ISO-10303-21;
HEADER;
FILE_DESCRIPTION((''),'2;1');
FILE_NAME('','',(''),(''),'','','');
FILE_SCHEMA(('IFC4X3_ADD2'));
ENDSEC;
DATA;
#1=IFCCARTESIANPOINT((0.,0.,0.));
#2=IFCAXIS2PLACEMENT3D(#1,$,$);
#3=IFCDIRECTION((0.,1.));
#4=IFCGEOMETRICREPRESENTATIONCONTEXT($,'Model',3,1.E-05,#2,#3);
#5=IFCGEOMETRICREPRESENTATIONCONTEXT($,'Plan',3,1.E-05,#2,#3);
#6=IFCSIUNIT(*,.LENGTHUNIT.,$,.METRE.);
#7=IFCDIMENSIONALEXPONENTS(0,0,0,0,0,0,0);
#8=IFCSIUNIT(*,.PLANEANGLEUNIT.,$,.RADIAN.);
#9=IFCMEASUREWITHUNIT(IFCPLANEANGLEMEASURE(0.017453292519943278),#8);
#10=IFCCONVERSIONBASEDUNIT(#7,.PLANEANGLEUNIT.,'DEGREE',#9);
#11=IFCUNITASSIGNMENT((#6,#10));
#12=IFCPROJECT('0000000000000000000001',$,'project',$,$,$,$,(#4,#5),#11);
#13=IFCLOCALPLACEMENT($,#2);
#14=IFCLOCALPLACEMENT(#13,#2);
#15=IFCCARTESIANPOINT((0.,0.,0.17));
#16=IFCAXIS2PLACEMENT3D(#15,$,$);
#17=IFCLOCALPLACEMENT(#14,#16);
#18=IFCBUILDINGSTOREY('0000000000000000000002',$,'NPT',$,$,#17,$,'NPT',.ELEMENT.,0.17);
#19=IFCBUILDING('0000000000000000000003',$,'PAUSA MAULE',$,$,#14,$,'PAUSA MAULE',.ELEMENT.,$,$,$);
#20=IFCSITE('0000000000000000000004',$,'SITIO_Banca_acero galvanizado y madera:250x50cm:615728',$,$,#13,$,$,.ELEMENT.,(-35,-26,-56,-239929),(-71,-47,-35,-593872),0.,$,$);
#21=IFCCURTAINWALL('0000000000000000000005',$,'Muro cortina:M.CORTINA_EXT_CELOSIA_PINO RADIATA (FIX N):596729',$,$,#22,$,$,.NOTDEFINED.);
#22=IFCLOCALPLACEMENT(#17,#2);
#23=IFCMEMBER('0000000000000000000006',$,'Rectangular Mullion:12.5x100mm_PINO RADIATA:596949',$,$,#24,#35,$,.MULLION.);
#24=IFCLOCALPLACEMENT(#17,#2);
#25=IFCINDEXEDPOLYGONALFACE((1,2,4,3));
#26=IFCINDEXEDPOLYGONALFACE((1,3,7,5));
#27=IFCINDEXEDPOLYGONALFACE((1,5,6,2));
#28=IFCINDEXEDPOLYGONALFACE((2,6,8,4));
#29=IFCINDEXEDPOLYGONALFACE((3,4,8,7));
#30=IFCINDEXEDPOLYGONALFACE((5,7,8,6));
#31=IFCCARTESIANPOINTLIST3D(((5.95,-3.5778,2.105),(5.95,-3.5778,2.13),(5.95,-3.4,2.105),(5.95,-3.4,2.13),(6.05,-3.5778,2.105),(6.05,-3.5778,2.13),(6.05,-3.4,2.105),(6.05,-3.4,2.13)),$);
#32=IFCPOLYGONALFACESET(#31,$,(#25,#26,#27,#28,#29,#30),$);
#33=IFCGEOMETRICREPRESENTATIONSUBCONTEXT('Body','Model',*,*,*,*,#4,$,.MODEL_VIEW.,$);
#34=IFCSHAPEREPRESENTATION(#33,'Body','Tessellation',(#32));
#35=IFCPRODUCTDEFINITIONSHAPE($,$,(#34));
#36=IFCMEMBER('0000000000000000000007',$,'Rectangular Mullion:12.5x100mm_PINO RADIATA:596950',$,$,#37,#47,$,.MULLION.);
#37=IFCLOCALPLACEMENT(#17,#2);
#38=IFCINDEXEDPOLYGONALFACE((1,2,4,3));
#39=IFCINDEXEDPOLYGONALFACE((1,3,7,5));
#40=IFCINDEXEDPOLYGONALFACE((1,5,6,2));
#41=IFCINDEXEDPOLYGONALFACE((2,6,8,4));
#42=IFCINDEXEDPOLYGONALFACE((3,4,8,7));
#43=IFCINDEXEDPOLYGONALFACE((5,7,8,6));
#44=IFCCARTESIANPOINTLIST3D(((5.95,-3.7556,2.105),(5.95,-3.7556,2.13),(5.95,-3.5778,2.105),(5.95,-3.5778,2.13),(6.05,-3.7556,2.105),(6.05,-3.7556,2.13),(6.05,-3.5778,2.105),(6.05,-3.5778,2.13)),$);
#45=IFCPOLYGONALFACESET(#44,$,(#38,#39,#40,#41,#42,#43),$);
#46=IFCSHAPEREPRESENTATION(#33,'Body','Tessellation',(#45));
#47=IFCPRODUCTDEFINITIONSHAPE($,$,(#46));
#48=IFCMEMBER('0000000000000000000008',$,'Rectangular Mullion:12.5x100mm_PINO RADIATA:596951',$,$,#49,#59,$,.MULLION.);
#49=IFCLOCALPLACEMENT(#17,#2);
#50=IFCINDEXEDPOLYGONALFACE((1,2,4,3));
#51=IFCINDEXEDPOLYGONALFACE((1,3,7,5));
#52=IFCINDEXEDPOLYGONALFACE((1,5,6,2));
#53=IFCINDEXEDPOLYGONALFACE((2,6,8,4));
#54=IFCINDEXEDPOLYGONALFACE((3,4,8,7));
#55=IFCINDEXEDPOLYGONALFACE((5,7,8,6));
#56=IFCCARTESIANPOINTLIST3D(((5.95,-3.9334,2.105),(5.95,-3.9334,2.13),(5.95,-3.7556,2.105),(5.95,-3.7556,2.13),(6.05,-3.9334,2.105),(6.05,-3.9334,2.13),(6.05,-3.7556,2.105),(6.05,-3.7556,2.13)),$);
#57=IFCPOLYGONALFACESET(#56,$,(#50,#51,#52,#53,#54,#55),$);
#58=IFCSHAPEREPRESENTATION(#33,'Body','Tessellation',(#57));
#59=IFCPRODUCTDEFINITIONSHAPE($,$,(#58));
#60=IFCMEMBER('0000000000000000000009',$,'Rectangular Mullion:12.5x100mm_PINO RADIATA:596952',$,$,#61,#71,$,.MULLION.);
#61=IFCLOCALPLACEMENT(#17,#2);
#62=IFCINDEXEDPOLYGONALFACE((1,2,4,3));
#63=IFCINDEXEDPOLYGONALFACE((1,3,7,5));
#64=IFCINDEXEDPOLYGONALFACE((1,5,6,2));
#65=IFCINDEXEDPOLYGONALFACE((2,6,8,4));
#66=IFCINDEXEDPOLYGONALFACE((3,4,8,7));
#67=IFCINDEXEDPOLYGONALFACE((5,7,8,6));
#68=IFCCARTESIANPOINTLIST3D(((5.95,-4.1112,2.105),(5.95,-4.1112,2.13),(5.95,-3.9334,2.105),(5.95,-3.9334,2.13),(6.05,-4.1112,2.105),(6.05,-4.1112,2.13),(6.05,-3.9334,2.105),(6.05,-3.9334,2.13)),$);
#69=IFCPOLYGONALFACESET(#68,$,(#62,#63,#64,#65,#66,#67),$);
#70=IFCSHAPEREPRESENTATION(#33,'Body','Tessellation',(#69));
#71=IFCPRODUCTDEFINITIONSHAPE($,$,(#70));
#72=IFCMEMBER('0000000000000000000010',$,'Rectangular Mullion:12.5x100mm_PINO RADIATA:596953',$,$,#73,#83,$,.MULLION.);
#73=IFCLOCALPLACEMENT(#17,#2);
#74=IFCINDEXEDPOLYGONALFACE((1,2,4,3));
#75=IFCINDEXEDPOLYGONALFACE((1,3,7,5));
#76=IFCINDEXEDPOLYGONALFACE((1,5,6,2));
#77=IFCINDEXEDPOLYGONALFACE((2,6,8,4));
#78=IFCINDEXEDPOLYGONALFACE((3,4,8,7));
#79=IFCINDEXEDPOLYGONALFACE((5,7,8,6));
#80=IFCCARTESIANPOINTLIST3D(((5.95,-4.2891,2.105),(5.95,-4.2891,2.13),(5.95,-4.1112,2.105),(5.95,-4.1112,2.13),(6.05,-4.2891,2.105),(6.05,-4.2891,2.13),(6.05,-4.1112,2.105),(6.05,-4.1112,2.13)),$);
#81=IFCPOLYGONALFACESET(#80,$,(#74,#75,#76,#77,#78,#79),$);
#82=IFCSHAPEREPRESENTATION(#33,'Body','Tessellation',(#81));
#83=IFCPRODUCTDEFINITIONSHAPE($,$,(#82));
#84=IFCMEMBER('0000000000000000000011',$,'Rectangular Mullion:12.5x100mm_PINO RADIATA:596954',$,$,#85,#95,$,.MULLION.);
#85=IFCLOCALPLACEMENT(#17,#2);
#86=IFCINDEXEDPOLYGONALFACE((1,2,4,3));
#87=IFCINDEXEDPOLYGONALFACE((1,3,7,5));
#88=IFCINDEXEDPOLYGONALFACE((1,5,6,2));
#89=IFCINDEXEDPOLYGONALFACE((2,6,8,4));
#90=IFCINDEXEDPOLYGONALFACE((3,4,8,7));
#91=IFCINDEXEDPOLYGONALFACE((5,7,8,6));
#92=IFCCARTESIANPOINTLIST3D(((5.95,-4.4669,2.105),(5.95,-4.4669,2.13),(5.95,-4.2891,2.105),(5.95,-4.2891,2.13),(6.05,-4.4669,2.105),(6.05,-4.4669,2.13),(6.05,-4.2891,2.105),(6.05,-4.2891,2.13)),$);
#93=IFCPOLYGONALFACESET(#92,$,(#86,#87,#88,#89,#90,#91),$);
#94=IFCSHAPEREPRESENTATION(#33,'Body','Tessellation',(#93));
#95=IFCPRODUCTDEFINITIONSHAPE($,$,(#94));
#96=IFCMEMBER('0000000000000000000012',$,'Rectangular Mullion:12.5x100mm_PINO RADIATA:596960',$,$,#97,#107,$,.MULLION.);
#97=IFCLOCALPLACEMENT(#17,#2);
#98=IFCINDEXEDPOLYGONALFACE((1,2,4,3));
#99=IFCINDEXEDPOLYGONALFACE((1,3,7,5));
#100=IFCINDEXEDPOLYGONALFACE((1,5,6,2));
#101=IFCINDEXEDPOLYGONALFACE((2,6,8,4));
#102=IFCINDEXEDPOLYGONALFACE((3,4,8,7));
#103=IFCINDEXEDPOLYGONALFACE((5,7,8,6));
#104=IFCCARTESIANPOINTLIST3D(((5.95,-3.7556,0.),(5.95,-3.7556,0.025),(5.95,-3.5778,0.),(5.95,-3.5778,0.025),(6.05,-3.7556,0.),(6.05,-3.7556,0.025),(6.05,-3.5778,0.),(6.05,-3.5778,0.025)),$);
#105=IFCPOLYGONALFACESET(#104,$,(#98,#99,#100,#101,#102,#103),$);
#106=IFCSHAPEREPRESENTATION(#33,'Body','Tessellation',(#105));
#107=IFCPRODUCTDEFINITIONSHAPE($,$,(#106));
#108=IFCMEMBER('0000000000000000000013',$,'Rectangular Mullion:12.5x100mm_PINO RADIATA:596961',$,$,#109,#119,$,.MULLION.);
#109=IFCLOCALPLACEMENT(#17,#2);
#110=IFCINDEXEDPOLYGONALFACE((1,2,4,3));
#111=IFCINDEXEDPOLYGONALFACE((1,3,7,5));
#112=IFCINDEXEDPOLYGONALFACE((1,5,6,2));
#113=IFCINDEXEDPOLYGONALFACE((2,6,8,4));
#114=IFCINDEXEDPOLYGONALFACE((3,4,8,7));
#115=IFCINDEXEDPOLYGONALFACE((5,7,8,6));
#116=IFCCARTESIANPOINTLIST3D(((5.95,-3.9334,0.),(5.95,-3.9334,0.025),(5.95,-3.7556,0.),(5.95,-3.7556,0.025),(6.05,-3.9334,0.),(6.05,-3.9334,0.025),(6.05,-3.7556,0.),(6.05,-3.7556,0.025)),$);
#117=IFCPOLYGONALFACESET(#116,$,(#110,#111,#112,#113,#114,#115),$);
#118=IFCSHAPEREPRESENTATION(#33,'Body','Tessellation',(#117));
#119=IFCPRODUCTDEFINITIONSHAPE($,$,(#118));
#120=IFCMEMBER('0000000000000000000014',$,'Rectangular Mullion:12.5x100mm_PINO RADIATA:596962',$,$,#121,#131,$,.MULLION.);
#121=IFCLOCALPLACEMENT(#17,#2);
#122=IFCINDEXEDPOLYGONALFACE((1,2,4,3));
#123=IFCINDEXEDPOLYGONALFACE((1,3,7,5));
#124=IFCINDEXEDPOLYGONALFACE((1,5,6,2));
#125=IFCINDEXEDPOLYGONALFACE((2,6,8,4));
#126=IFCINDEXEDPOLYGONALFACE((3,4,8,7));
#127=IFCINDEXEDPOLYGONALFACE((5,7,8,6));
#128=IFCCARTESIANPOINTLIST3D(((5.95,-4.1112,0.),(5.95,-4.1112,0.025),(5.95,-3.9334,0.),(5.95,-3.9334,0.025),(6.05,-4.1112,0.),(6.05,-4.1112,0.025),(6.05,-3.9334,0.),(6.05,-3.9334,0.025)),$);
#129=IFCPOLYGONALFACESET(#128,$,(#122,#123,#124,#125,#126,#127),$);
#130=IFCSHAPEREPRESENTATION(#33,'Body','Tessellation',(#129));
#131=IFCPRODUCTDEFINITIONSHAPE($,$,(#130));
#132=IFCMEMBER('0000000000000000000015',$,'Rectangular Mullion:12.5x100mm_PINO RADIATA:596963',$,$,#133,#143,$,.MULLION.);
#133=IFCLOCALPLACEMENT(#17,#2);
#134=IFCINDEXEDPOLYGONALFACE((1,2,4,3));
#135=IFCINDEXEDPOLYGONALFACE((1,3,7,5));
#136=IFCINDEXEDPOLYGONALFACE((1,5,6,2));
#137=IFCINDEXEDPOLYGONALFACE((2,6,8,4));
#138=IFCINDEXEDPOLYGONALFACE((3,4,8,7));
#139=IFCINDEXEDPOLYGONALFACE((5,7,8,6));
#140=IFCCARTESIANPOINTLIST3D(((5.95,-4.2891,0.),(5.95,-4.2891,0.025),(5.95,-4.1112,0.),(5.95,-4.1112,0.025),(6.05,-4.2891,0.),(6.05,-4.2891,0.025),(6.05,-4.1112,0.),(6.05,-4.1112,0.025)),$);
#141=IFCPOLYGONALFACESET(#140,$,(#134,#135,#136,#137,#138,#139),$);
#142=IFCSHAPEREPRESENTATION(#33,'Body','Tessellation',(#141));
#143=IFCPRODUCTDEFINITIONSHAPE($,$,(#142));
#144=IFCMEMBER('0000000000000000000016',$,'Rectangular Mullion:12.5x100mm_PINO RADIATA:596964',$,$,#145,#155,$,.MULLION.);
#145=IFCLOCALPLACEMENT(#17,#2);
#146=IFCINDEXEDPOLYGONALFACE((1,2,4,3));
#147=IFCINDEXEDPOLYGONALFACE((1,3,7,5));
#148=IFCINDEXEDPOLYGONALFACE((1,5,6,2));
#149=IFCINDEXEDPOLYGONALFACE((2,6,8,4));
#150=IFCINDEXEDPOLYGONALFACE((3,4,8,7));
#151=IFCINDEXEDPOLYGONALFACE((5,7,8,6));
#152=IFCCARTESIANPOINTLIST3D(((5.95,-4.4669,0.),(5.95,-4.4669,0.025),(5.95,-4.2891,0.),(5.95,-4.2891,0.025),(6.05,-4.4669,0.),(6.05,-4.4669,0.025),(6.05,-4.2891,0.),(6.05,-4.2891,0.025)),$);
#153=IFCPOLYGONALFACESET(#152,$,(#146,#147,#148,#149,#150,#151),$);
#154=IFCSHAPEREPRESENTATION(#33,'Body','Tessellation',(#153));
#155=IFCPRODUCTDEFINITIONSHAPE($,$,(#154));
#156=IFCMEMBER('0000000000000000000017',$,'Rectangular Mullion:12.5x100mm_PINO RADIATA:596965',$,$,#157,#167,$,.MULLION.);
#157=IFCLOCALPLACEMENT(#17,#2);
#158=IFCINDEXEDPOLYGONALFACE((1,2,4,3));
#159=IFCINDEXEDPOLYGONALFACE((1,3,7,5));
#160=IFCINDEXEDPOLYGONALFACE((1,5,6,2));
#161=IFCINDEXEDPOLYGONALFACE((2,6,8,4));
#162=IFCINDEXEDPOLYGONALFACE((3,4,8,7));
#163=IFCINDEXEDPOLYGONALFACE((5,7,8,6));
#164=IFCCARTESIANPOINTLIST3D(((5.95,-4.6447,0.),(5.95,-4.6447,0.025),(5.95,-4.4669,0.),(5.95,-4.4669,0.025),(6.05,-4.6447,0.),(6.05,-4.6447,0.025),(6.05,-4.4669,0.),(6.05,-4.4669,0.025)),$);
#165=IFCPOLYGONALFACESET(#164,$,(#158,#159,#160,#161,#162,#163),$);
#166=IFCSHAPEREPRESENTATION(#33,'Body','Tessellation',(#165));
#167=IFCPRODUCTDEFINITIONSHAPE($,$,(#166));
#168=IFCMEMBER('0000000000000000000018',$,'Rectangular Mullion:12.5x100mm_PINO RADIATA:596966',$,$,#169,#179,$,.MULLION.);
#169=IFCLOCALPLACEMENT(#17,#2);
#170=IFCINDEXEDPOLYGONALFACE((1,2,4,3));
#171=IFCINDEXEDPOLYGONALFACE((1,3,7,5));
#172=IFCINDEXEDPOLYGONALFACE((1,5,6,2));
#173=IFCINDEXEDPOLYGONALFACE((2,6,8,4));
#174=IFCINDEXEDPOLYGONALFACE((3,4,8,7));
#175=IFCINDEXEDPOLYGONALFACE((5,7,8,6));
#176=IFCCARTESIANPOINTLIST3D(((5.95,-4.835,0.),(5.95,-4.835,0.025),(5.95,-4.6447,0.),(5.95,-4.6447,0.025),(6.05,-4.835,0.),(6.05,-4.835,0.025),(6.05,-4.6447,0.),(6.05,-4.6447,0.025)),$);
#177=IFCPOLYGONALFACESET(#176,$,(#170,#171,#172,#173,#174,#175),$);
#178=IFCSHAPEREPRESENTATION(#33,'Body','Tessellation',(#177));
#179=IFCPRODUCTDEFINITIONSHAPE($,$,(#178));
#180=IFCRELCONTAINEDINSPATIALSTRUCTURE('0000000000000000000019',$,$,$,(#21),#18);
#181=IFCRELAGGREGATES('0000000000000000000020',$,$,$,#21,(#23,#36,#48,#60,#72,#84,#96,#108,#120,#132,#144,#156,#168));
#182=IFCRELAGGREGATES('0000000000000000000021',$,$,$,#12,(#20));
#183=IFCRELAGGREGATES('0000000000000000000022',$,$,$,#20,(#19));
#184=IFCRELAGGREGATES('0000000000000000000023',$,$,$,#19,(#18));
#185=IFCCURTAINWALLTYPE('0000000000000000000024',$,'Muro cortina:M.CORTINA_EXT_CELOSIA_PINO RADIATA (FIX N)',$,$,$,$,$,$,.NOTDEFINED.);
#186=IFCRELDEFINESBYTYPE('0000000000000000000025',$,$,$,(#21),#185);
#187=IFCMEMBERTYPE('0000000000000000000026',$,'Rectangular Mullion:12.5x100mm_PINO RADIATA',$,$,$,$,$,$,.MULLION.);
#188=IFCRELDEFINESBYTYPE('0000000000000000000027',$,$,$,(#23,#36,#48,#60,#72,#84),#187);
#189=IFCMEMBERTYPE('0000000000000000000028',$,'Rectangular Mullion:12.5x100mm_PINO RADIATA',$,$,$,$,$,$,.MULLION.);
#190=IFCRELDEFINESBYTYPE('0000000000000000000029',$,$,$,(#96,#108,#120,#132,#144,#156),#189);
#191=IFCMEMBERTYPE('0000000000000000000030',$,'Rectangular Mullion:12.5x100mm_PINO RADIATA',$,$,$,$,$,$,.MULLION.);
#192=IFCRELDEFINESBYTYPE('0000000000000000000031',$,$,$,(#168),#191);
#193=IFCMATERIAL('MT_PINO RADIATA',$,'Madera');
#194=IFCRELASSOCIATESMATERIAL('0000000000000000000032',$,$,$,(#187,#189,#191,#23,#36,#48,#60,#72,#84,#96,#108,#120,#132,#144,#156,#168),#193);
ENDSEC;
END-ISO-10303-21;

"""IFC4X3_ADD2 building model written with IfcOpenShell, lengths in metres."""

from ifc_helpers import new_model, entity, si_unit, converted_unit, direction, frame, frame_2d, origin, place, context, subcontext, project, spatial, rectangle, extrude, source, transform, mapped, material, material_profile, profile_set, profile_usage, type_object, type_shapes, element, aggregate, save


model = new_model("IFC4X3_ADD2")

# Units and contexts
model_context = context("Model", 3, precision=1e-05, world=origin(), true_north=direction((0.0, 1.0)))
plan_context = context("Plan", 3, precision=1e-05, world=origin(), true_north=direction((0.0, 1.0)))
body_context = subcontext(model_context, "Body", "Model", "MODEL_VIEW")
ifc_project = project(units=[si_unit("LENGTHUNIT", "METRE"), converted_unit("PLANEANGLEUNIT", "DEGREE", entity("IfcPlaneAngleMeasure", 0.017453292519943278), si_unit("PLANEANGLEUNIT", "RADIAN"), dimensions=[0, 0, 0, 0, 0, 0, 0])], contexts=[model_context, plan_context])

# Site, building, storey
site_placement = place(None, origin())
site = spatial("IfcSite", under=ifc_project, at=site_placement, Name="SITIO_Banca_acero galvanizado y madera:250x50cm:615728", CompositionType="ELEMENT", RefLatitude=(-35, -26, -56, -239929), RefLongitude=(-71, -47, -35, -593872), RefElevation=0.0)
building_placement = place(site_placement, origin())
building = spatial("IfcBuilding", under=site, at=building_placement, Name="PAUSA MAULE", LongName="PAUSA MAULE", CompositionType="ELEMENT")
storey_placement = place(building_placement, frame((0.0, 0.0, 0.17)))
storey = spatial("IfcBuildingStorey", under=building, at=storey_placement, Name="NPT", LongName="NPT", CompositionType="ELEMENT", Elevation=0.17)

# Curtain wall, members
curtain_wall_type = type_object("IfcCurtainWallType", Name="Muro cortina:M.CORTINA_EXT_CELOSIA_PINO RADIATA (FIX N)", PredefinedType="NOTDEFINED")
curtain_wall_placement = place(storey_placement, frame((0.0, 0.0, -0.17)))
curtain_wall = element("IfcCurtainWall", 1, at=curtain_wall_placement, inside=storey, type_object=curtain_wall_type, Name="Muro cortina:M.CORTINA_EXT_CELOSIA_PINO RADIATA (FIX N):596729", PredefinedType="NOTDEFINED")
ifc_material = material(Name="MT_PINO RADIATA", Category="Madera")
ifc_material_profile = material_profile(ifc_material, rectangle(XDim=0.025, YDim=0.1, at=frame_2d((0.0, 0.0), x_axis=(1.0, 0.0))), Name="12.5x100mm_PINO RADIATA")
ifc_profile_set = profile_set([ifc_material_profile], Name="12.5x100mm_PINO RADIATA")
ifc_profile_usage = profile_usage(ifc_profile_set)
member_type_1 = type_object("IfcMemberType", Name="Rectangular Mullion:12.5x100mm_PINO RADIATA", PredefinedType="MULLION", material=ifc_profile_set)
shared_shape_1 = source(origin(), body_context, "Body", "SweptSolid", [
    extrude(rectangle(XDim=0.025, YDim=0.1, at=frame_2d((0.0, 0.0), x_axis=(1.0, 0.0))), frame((-0.0125, 0.0, -0.1778), z_axis=(0.0, 0.0, 1.0), x_axis=(-1.0, 0.0, 0.0)), (0.0, 0.0, 1.0), 0.1778),
])
type_shapes(member_type_1, [shared_shape_1])
member_1_placement = place(curtain_wall_placement, frame((6.0, -3.5778, 2.3), z_axis=(0.0, -1.0, 0.0), x_axis=(0.0, 0.0, 1.0)))
member_1 = element("IfcMember", 2, at=member_1_placement, type_object=member_type_1, material=ifc_profile_usage, Name="Rectangular Mullion:12.5x100mm_PINO RADIATA:596949", PredefinedType="MULLION", context=body_context, shape_type="MappedRepresentation", body=[
    mapped(shared_shape_1, transform((0.0, 0.0, 0.0), scale=1.0)),
])
member_2_placement = place(curtain_wall_placement, frame((6.0, -3.7556, 2.3), z_axis=(0.0, -1.0, 0.0), x_axis=(0.0, 0.0, 1.0)))
member_2 = element("IfcMember", 3, at=member_2_placement, type_object=member_type_1, material=ifc_profile_usage, Name="Rectangular Mullion:12.5x100mm_PINO RADIATA:596950", PredefinedType="MULLION", context=body_context, shape_type="MappedRepresentation", body=[
    mapped(shared_shape_1, transform((0.0, 0.0, 0.0), scale=1.0)),
])
member_3_placement = place(curtain_wall_placement, frame((6.0, -3.9334, 2.3), z_axis=(0.0, -1.0, 0.0), x_axis=(0.0, 0.0, 1.0)))
member_3 = element("IfcMember", 4, at=member_3_placement, type_object=member_type_1, material=ifc_profile_usage, Name="Rectangular Mullion:12.5x100mm_PINO RADIATA:596951", PredefinedType="MULLION", context=body_context, shape_type="MappedRepresentation", body=[
    mapped(shared_shape_1, transform((0.0, 0.0, 0.0), scale=1.0)),
])
member_4_placement = place(curtain_wall_placement, frame((6.0, -4.1112, 2.3), z_axis=(0.0, -1.0, 0.0), x_axis=(0.0, 0.0, 1.0)))
member_4 = element("IfcMember", 5, at=member_4_placement, type_object=member_type_1, material=ifc_profile_usage, Name="Rectangular Mullion:12.5x100mm_PINO RADIATA:596952", PredefinedType="MULLION", context=body_context, shape_type="MappedRepresentation", body=[
    mapped(shared_shape_1, transform((0.0, 0.0, 0.0), scale=1.0)),
])
member_5_placement = place(curtain_wall_placement, frame((6.0, -4.2891, 2.3), z_axis=(0.0, -1.0, 0.0), x_axis=(0.0, 0.0, 1.0)))
member_5 = element("IfcMember", 6, at=member_5_placement, type_object=member_type_1, material=ifc_profile_usage, Name="Rectangular Mullion:12.5x100mm_PINO RADIATA:596953", PredefinedType="MULLION", context=body_context, shape_type="MappedRepresentation", body=[
    mapped(shared_shape_1, transform((0.0, 0.0, 0.0), scale=1.0)),
])
member_6_placement = place(curtain_wall_placement, frame((6.0, -4.4669, 2.3), z_axis=(0.0, -1.0, 0.0), x_axis=(0.0, 0.0, 1.0)))
member_6 = element("IfcMember", 7, at=member_6_placement, type_object=member_type_1, material=ifc_profile_usage, Name="Rectangular Mullion:12.5x100mm_PINO RADIATA:596954", PredefinedType="MULLION", context=body_context, shape_type="MappedRepresentation", body=[
    mapped(shared_shape_1, transform((0.0, 0.0, 0.0), scale=1.0)),
])
member_type_2 = type_object("IfcMemberType", Name="Rectangular Mullion:12.5x100mm_PINO RADIATA", PredefinedType="MULLION", material=ifc_profile_set)
shared_shape_2 = source(origin(), body_context, "Body", "SweptSolid", [
    extrude(rectangle(XDim=0.025, YDim=0.1, at=frame_2d((0.0, 0.0), x_axis=(1.0, 0.0))), frame((-0.0125, 0.0, -0.1778), z_axis=(0.0, 0.0, 1.0), x_axis=(-1.0, 0.0, 0.0)), (0.0, 0.0, 1.0), 0.1778),
])
type_shapes(member_type_2, [shared_shape_2])
member_7_placement = place(curtain_wall_placement, frame((6.0, -3.5778, 0.17), z_axis=(0.0, 1.0, 0.0), x_axis=(0.0, 0.0, -1.0)))
member_7 = element("IfcMember", 8, at=member_7_placement, type_object=member_type_2, material=ifc_profile_usage, Name="Rectangular Mullion:12.5x100mm_PINO RADIATA:596960", PredefinedType="MULLION", context=body_context, shape_type="MappedRepresentation", body=[
    mapped(shared_shape_2, transform((0.0, 0.0, 0.0), scale=1.0)),
])
member_8_placement = place(curtain_wall_placement, frame((6.0, -3.7556, 0.17), z_axis=(0.0, 1.0, 0.0), x_axis=(0.0, 0.0, -1.0)))
member_8 = element("IfcMember", 9, at=member_8_placement, type_object=member_type_2, material=ifc_profile_usage, Name="Rectangular Mullion:12.5x100mm_PINO RADIATA:596961", PredefinedType="MULLION", context=body_context, shape_type="MappedRepresentation", body=[
    mapped(shared_shape_2, transform((0.0, 0.0, 0.0), scale=1.0)),
])
member_9_placement = place(curtain_wall_placement, frame((6.0, -3.9334, 0.17), z_axis=(0.0, 1.0, 0.0), x_axis=(0.0, 0.0, -1.0)))
member_9 = element("IfcMember", 10, at=member_9_placement, type_object=member_type_2, material=ifc_profile_usage, Name="Rectangular Mullion:12.5x100mm_PINO RADIATA:596962", PredefinedType="MULLION", context=body_context, shape_type="MappedRepresentation", body=[
    mapped(shared_shape_2, transform((0.0, 0.0, 0.0), scale=1.0)),
])
member_10_placement = place(curtain_wall_placement, frame((6.0, -4.1112, 0.17), z_axis=(0.0, 1.0, 0.0), x_axis=(0.0, 0.0, -1.0)))
member_10 = element("IfcMember", 11, at=member_10_placement, type_object=member_type_2, material=ifc_profile_usage, Name="Rectangular Mullion:12.5x100mm_PINO RADIATA:596963", PredefinedType="MULLION", context=body_context, shape_type="MappedRepresentation", body=[
    mapped(shared_shape_2, transform((0.0, 0.0, 0.0), scale=1.0)),
])
member_11_placement = place(curtain_wall_placement, frame((6.0, -4.2891, 0.17), z_axis=(0.0, 1.0, 0.0), x_axis=(0.0, 0.0, -1.0)))
member_11 = element("IfcMember", 12, at=member_11_placement, type_object=member_type_2, material=ifc_profile_usage, Name="Rectangular Mullion:12.5x100mm_PINO RADIATA:596964", PredefinedType="MULLION", context=body_context, shape_type="MappedRepresentation", body=[
    mapped(shared_shape_2, transform((0.0, 0.0, 0.0), scale=1.0)),
])
member_12_placement = place(curtain_wall_placement, frame((6.0, -4.4669, 0.17), z_axis=(0.0, 1.0, 0.0), x_axis=(0.0, 0.0, -1.0)))
member_12 = element("IfcMember", 13, at=member_12_placement, type_object=member_type_2, material=ifc_profile_usage, Name="Rectangular Mullion:12.5x100mm_PINO RADIATA:596965", PredefinedType="MULLION", context=body_context, shape_type="MappedRepresentation", body=[
    mapped(shared_shape_2, transform((0.0, 0.0, 0.0), scale=1.0)),
])
member_type_3 = type_object("IfcMemberType", Name="Rectangular Mullion:12.5x100mm_PINO RADIATA", PredefinedType="MULLION", material=ifc_profile_set)
shared_shape_3 = source(origin(), body_context, "Body", "SweptSolid", [
    extrude(rectangle(XDim=0.025, YDim=0.1, at=frame_2d((0.0, 0.0), x_axis=(1.0, 0.0))), frame((-0.0125, 0.0, -0.1903), z_axis=(0.0, 0.0, 1.0), x_axis=(-1.0, 0.0, 0.0)), (0.0, 0.0, 1.0), 0.1903),
])
type_shapes(member_type_3, [shared_shape_3])
member_13_placement = place(curtain_wall_placement, frame((6.0, -4.6447, 0.17), z_axis=(0.0, 1.0, 0.0), x_axis=(0.0, 0.0, -1.0)))
member_13 = element("IfcMember", 14, at=member_13_placement, type_object=member_type_3, material=ifc_profile_usage, Name="Rectangular Mullion:12.5x100mm_PINO RADIATA:596966", PredefinedType="MULLION", context=body_context, shape_type="MappedRepresentation", body=[
    mapped(shared_shape_3, transform((0.0, 0.0, 0.0), scale=1.0)),
])
aggregate(curtain_wall, [member_1, member_2, member_3, member_4, member_5, member_6, member_7, member_8, member_9, member_10, member_11, member_12, member_13])

save(model, "model.ifc")
